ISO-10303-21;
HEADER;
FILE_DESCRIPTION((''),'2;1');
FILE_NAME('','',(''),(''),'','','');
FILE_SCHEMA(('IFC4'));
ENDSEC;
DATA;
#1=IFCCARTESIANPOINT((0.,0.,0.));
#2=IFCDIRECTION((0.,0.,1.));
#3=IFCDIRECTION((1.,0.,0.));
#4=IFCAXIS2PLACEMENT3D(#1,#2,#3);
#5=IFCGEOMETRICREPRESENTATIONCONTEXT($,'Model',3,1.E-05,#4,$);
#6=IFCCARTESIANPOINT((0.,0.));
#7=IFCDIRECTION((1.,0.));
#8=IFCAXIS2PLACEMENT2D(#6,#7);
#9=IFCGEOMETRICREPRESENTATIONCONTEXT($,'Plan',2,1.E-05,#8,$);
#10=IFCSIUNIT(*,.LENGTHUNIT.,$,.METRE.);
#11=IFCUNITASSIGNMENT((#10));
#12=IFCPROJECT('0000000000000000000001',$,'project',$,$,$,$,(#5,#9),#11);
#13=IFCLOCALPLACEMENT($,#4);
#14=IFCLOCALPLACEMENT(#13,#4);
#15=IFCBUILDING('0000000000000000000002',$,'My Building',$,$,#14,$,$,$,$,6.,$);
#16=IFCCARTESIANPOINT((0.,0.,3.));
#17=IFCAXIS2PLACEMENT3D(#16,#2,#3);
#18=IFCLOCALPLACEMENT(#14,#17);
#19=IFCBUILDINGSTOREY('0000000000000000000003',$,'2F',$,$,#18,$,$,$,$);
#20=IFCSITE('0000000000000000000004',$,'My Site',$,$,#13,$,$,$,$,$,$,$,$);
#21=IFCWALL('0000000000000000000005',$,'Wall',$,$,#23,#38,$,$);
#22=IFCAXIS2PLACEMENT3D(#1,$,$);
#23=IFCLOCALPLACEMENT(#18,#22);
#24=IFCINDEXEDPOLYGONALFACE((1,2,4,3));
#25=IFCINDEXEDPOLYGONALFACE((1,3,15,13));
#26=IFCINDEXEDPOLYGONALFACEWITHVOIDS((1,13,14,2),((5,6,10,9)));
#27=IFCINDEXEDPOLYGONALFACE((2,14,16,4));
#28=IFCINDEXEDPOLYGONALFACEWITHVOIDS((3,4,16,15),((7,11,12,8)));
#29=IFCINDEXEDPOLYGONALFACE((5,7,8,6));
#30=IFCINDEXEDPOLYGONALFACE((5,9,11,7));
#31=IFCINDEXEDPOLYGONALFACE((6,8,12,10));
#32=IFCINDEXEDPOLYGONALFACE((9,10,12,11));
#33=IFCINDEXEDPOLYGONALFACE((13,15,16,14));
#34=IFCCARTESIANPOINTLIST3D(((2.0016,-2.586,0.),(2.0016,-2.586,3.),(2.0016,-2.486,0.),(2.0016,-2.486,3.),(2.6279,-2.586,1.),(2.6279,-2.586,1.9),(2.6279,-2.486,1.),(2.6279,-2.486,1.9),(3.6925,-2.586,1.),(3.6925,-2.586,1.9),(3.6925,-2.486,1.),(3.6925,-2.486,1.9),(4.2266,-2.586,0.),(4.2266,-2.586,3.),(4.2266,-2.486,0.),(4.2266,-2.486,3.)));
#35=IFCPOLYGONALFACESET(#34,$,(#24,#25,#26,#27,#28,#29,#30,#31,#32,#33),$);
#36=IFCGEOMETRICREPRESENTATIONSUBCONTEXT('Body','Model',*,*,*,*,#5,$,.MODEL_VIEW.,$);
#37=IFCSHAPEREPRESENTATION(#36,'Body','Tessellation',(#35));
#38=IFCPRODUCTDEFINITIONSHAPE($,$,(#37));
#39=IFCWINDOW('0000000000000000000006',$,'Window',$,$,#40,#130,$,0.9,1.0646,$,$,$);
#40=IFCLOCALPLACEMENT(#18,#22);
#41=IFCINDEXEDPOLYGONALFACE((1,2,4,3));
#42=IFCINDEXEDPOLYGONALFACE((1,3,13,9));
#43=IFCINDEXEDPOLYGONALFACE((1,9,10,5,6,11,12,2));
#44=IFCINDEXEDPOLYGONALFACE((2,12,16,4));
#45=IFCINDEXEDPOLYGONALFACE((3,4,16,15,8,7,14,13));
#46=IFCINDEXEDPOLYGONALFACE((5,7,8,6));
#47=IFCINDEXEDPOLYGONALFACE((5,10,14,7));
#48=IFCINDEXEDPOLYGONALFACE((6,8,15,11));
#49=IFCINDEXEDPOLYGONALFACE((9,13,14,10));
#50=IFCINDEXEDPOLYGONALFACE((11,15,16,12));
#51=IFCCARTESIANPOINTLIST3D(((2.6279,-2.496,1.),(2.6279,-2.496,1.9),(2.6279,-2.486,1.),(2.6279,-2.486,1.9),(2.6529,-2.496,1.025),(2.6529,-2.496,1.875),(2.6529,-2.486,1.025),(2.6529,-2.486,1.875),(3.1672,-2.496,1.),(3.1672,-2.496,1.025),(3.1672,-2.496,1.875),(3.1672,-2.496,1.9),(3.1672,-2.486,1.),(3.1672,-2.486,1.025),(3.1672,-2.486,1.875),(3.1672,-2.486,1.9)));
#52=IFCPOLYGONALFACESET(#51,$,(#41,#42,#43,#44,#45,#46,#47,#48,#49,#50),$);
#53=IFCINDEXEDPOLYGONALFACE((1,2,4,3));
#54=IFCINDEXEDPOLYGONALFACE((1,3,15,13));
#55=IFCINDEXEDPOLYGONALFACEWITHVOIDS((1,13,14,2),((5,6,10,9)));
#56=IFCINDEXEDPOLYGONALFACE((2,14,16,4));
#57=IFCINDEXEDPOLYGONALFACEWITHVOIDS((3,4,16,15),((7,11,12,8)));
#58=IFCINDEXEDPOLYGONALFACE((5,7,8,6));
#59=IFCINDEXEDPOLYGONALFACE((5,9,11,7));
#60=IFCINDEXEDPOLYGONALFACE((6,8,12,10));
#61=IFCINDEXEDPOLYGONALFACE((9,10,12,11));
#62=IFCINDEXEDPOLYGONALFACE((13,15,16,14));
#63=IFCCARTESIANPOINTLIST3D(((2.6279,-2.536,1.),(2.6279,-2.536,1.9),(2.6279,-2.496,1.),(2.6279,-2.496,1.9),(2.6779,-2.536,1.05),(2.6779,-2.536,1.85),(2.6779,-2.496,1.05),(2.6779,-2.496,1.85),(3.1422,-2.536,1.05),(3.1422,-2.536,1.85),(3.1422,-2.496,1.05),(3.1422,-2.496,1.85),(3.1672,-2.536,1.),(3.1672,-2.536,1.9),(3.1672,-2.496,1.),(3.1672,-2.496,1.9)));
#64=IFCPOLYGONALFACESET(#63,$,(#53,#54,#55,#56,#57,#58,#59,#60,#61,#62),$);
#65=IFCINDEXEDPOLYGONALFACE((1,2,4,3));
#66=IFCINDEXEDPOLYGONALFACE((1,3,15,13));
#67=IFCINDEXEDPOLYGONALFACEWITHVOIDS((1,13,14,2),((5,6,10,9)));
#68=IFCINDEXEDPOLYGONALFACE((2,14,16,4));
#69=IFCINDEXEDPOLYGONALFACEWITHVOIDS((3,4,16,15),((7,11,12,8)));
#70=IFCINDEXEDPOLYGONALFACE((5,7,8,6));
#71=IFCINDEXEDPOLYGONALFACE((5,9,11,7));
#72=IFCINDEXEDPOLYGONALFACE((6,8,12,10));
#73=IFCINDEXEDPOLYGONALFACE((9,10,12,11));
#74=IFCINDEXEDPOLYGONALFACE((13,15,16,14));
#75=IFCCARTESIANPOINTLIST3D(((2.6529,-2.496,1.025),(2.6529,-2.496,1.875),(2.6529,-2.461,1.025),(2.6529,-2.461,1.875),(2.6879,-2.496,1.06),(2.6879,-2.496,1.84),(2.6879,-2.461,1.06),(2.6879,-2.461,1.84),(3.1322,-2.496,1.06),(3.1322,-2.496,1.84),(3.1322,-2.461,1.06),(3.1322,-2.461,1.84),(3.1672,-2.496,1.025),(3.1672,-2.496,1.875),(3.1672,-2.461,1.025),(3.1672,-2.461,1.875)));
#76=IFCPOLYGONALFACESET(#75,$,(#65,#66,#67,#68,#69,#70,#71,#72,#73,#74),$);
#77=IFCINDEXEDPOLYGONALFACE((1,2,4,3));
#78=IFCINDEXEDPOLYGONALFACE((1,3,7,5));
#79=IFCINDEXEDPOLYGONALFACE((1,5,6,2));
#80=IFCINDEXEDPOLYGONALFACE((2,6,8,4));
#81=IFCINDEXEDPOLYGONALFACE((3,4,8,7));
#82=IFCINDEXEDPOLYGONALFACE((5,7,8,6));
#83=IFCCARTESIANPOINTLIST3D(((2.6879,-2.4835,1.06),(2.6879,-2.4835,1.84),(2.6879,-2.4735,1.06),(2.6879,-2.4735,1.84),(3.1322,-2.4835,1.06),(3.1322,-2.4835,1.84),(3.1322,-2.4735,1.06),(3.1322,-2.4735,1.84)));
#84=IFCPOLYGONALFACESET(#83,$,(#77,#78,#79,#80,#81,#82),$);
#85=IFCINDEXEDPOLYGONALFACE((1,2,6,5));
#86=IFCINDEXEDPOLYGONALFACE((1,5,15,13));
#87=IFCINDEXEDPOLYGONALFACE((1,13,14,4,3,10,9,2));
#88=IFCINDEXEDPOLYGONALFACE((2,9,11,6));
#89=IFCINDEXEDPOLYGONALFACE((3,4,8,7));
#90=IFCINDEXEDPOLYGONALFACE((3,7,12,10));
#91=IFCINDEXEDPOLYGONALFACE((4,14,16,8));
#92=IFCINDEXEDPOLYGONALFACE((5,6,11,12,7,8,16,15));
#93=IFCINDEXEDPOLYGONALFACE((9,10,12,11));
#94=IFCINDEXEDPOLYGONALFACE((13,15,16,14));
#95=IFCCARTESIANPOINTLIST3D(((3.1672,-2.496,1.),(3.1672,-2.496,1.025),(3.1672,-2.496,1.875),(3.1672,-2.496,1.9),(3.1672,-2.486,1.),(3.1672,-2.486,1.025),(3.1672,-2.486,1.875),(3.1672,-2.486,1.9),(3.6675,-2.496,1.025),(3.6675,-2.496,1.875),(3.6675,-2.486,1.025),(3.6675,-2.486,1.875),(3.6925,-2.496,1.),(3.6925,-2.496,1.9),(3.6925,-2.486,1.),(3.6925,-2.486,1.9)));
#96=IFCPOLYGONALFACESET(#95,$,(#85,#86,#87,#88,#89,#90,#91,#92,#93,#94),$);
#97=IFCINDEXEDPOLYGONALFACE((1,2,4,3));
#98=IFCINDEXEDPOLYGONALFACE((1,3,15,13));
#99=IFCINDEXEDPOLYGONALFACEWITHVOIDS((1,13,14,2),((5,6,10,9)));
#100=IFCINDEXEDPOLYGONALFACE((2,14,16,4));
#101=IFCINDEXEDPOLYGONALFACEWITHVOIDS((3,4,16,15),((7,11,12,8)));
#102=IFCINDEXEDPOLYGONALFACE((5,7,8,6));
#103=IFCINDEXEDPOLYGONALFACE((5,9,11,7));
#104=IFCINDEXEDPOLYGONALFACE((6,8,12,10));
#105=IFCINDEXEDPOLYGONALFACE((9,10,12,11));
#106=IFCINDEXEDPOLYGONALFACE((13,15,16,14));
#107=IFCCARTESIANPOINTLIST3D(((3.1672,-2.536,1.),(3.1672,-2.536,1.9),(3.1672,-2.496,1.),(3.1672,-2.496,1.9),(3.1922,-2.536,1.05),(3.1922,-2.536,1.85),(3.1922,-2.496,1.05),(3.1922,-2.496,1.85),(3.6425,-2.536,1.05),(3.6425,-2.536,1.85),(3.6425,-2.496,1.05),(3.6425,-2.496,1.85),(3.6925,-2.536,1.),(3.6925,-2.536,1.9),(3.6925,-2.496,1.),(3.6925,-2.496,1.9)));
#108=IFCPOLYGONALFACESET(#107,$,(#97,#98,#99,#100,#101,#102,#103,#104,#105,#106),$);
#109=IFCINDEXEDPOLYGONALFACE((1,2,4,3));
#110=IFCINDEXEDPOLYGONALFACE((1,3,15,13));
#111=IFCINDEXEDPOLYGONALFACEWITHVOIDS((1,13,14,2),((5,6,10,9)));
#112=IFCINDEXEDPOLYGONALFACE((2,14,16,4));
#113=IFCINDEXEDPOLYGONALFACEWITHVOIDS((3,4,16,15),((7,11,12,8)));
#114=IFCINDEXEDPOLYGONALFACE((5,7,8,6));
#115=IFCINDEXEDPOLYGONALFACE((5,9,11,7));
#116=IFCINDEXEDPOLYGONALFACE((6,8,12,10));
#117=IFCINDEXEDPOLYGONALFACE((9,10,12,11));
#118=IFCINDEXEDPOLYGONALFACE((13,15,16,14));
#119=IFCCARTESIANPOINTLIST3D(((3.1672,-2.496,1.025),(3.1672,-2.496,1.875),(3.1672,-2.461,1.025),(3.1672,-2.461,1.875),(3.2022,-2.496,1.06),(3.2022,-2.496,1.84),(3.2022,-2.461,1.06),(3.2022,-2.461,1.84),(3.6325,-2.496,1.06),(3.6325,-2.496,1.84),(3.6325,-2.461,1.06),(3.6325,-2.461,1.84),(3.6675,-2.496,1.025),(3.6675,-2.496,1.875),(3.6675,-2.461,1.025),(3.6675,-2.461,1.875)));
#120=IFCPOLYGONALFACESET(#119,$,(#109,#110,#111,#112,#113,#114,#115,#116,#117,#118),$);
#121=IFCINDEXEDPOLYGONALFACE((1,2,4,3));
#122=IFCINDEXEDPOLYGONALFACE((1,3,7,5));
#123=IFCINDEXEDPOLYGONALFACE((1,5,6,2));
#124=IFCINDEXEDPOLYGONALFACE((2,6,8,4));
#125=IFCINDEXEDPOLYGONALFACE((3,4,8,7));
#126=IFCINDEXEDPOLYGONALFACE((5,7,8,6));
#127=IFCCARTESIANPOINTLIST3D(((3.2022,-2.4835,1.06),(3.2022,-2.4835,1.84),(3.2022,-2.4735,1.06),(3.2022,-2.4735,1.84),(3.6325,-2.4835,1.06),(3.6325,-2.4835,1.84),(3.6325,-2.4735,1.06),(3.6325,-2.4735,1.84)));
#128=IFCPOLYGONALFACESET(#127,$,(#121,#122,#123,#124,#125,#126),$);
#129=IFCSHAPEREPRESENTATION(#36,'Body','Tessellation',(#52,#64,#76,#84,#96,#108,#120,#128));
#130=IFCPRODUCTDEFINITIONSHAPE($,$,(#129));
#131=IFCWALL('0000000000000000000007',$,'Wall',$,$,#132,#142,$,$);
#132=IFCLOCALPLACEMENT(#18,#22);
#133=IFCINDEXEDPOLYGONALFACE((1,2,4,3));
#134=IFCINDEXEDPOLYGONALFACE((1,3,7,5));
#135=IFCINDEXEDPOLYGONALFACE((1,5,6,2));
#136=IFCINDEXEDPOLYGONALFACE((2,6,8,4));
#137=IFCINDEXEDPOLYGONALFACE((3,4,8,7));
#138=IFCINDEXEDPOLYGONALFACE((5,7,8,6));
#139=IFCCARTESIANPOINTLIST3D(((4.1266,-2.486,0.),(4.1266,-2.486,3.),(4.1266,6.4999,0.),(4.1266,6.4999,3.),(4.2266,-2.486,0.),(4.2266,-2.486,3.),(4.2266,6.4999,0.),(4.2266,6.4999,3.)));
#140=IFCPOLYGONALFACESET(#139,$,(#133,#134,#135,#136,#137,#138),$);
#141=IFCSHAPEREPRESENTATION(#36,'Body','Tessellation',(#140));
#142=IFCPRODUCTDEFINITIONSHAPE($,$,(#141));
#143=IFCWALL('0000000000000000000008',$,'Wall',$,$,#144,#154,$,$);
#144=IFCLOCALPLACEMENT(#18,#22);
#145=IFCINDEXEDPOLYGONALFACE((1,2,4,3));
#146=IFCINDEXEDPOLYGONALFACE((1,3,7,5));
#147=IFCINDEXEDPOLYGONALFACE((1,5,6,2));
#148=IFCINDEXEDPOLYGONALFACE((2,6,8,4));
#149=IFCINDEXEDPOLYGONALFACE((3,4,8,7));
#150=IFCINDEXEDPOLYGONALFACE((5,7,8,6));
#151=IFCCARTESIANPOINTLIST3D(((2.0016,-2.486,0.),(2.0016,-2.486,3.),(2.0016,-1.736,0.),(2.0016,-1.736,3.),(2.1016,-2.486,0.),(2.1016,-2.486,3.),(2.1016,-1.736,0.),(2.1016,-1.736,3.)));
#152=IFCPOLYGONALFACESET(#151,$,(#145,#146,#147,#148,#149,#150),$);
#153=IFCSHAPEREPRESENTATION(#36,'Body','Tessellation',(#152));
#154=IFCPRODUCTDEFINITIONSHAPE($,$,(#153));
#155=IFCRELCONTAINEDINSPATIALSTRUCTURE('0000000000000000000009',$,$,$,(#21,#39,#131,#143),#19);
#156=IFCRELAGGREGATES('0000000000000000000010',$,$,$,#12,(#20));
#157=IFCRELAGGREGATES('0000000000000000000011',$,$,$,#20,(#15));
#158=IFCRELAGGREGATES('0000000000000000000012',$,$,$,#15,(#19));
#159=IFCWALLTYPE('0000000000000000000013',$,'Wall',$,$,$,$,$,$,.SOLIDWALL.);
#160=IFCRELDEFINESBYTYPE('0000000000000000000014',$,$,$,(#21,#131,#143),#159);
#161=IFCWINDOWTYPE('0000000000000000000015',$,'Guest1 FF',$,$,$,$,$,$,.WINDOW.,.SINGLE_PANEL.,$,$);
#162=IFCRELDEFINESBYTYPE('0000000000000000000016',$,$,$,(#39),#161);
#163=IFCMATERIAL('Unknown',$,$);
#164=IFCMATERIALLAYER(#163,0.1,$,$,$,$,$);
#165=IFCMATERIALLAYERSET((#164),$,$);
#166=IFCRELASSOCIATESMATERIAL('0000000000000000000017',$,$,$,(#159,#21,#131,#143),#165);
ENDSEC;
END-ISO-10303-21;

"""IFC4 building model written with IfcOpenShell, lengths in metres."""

from ifc_helpers import new_model, entity, si_unit, frame, origin_with_axes, origin_2d_with_axis, place, context, subcontext, project, spatial, line, indexed_curve, outline, extrude, shape, source, transform, mapped, material, layer, layer_set, layer_usage, type_object, type_shapes, element, fill, save


model = new_model("IFC4")

# Units and contexts
model_context = context("Model", 3, precision=1e-05, world=origin_with_axes())
plan_context = context("Plan", 2, precision=1e-05, world=origin_2d_with_axis())
body_context_1 = subcontext(model_context, "Body", "Model", "MODEL_VIEW")
body_context_2 = subcontext(plan_context, "Body", "Plan", "PLAN_VIEW")
ifc_project = project(units=[si_unit("LENGTHUNIT", "METRE")], contexts=[model_context, plan_context])

# Site, building, storey
site_placement = place(None, origin_with_axes())
site = spatial("IfcSite", under=ifc_project, at=site_placement, Name="My Site")
building_placement = place(site_placement, origin_with_axes())
building = spatial("IfcBuilding", under=site, at=building_placement, Name="My Building", ElevationOfTerrain=6.0)
storey_placement = place(building_placement, frame((0.0, 0.0, 3.0), z_axis=(0.0, 0.0, 1.0), x_axis=(1.0, 0.0, 0.0)))
storey = spatial("IfcBuildingStorey", under=building, at=storey_placement, Name="2F")

# Shared definitions
ifc_material_1 = material(Name="Unknown")

# Wall, opening, window
ifc_layer_1 = layer(ifc_material_1, 0.1)
ifc_layer_set_1 = layer_set([ifc_layer_1])
ifc_layer_usage_1 = layer_usage(ifc_layer_set_1, "AXIS2", "POSITIVE", 0.0)
wall_type = type_object("IfcWallType", Name="Wall", PredefinedType="SOLIDWALL", material=ifc_layer_set_1)
wall_1_placement = place(storey_placement, frame((4.2266, -2.486, 0.0), z_axis=(0.0, 0.0, 1.0), x_axis=(-1.0, 0.0, 0.0)))
wall_1 = element("IfcWall", 1, at=wall_1_placement, inside=storey, type_object=wall_type, material=ifc_layer_usage_1, Name="Wall", context=body_context_1, shape_type="SweptSolid", body=[
    extrude(outline(indexed_curve([(0.0, 0.0), (0.0, 0.1), (2.225, 0.1), (2.225, 0.0)], segments=[line(1, 2, 3, 4, 1)])), origin_with_axes(), (0.0, 0.0, 1.0), 3.0),
])
shared_shape_1 = source(origin_with_axes(), body_context_1, "Body", "SweptSolid", [
    extrude(outline(indexed_curve([(0.0, 0.0), (1.0646, 0.0), (1.0646, 0.9), (0.0, 0.9)], segments=[line(1, 2, 3, 4, 1)])), frame((0.0, -0.6, 0.0), z_axis=(0.0, -1.0, 0.0), x_axis=(1.0, 0.0, 0.0)), (0.0, 0.0, -1.0), 1.2),
])
opening_1_placement = place(wall_1_placement, frame((1.5987, 0.1, 1.0), z_axis=(0.0, 0.0, 1.0), x_axis=(-1.0, 0.0, 0.0)))
opening_1 = element("IfcOpeningElement", 2, at=opening_1_placement, cuts=wall_1, PredefinedType="OPENING", context=body_context_1, shape_type="MappedRepresentation", body=[
    mapped(shared_shape_1, transform((0.0, 0.0, 0.0), x_axis=(1.0, 0.0, 0.0), y_axis=(0.0, 1.0, 0.0), z_axis=(0.0, 0.0, 1.0), scale=1.0)),
])
window_type = type_object("IfcWindowType", Name="Guest1 FF", PartitioningType="SINGLE_PANEL", PredefinedType="WINDOW")
shared_shape_2 = source(origin_with_axes(), body_context_1, "Body", "SweptSolid", [
    extrude(outline(indexed_curve([(0.5393, 0.0), (0.0, 0.0), (0.0, 0.9), (0.5393, 0.9), (0.5393, 0.875), (0.025, 0.875), (0.025, 0.025), (0.5393, 0.025)], segments=[line(1, 2, 3, 4, 5, 6, 7, 8, 1)])), frame((0.0, 0.09, 0.0), z_axis=(0.0, -1.0, 0.0), x_axis=(1.0, 0.0, 0.0)), (0.0, 0.0, -1.0), 0.01),
    extrude(outline(indexed_curve([(0.0, 0.0), (0.5393, 0.0), (0.5393, 0.9), (0.0, 0.9)], segments=[line(1, 2, 3, 4, 1)]), holes=[indexed_curve([(0.05, 0.05), (0.5143, 0.05), (0.5143, 0.85), (0.05, 0.85)], segments=[line(1, 2, 3, 4, 1)])]), frame((0.0, 0.05, 0.0), z_axis=(0.0, -1.0, 0.0), x_axis=(1.0, 0.0, 0.0)), (0.0, 0.0, -1.0), 0.04),
    extrude(outline(indexed_curve([(0.0, 0.0), (0.5143, 0.0), (0.5143, 0.85), (0.0, 0.85)], segments=[line(1, 2, 3, 4, 1)]), holes=[indexed_curve([(0.035, 0.035), (0.4793, 0.035), (0.4793, 0.815), (0.035, 0.815)], segments=[line(1, 2, 3, 4, 1)])]), frame((0.025, 0.09, 0.025), z_axis=(0.0, -1.0, 0.0), x_axis=(1.0, 0.0, 0.0)), (0.0, 0.0, -1.0), 0.035),
    extrude(outline(indexed_curve([(0.035, 0.035), (0.4793, 0.035), (0.4793, 0.815), (0.035, 0.815)], segments=[line(1, 2, 3, 4, 1)])), frame((0.025, 0.1025, 0.025), z_axis=(0.0, -1.0, 0.0), x_axis=(1.0, 0.0, 0.0)), (0.0, 0.0, -1.0), 0.01),
    extrude(outline(indexed_curve([(0.0, 0.9), (0.5253, 0.9), (0.5253, 0.0), (0.0, 0.0), (0.0, 0.025), (0.5003, 0.025), (0.5003, 0.875), (0.0, 0.875)], segments=[line(1, 2, 3, 4, 5, 6, 7, 8, 1)])), frame((0.5393, 0.09, 0.0), z_axis=(0.0, -1.0, 0.0), x_axis=(1.0, 0.0, 0.0)), (0.0, 0.0, -1.0), 0.01),
    extrude(outline(indexed_curve([(0.0, 0.0), (0.5253, 0.0), (0.5253, 0.9), (0.0, 0.9)], segments=[line(1, 2, 3, 4, 1)]), holes=[indexed_curve([(0.025, 0.05), (0.4753, 0.05), (0.4753, 0.85), (0.025, 0.85)], segments=[line(1, 2, 3, 4, 1)])]), frame((0.5393, 0.05, 0.0), z_axis=(0.0, -1.0, 0.0), x_axis=(1.0, 0.0, 0.0)), (0.0, 0.0, -1.0), 0.04),
    extrude(outline(indexed_curve([(0.0, 0.0), (0.5003, 0.0), (0.5003, 0.85), (0.0, 0.85)], segments=[line(1, 2, 3, 4, 1)]), holes=[indexed_curve([(0.035, 0.035), (0.4653, 0.035), (0.4653, 0.815), (0.035, 0.815)], segments=[line(1, 2, 3, 4, 1)])]), frame((0.5393, 0.09, 0.025), z_axis=(0.0, -1.0, 0.0), x_axis=(1.0, 0.0, 0.0)), (0.0, 0.0, -1.0), 0.035),
    extrude(outline(indexed_curve([(0.035, 0.035), (0.4653, 0.035), (0.4653, 0.815), (0.035, 0.815)], segments=[line(1, 2, 3, 4, 1)])), frame((0.5393, 0.1025, 0.025), z_axis=(0.0, -1.0, 0.0), x_axis=(1.0, 0.0, 0.0)), (0.0, 0.0, -1.0), 0.01),
])
shared_shape_3 = source(origin_with_axes(), body_context_2, "Body", "Curve2D", [
    entity("IfcIndexedPolyCurve", entity("IfcCartesianPointList2D", [[0.05, 0.05], [0.5143, 0.05]])),
    entity("IfcIndexedPolyCurve", entity("IfcCartesianPointList2D", [[0.0, 0.1], [0.025, 0.1], [0.025, 0.09], [0.05, 0.09], [0.05, 0.05], [0.0, 0.05]]), [entity("IfcLineIndex", [1, 2, 3, 4, 5, 6, 1])]),
    entity("IfcIndexedPolyCurve", entity("IfcCartesianPointList2D", [[0.5393, 0.1], [0.5393, 0.1], [0.5393, 0.09], [0.5143, 0.09], [0.5143, 0.05], [0.5393, 0.05]])),
    entity("IfcIndexedPolyCurve", entity("IfcCartesianPointList2D", [[0.025, 0.09], [0.06, 0.09], [0.06, 0.125], [0.025, 0.125]]), [entity("IfcLineIndex", [1, 2, 3, 4, 1])]),
    entity("IfcIndexedPolyCurve", entity("IfcCartesianPointList2D", [[0.5393, 0.09], [0.5043, 0.09], [0.5043, 0.125], [0.5393, 0.125]]), [entity("IfcLineIndex", [1, 2, 3, 4, 1])]),
    entity("IfcIndexedPolyCurve", entity("IfcCartesianPointList2D", [[0.06, 0.09], [0.5043, 0.09]])),
    entity("IfcIndexedPolyCurve", entity("IfcCartesianPointList2D", [[0.06, 0.125], [0.5043, 0.125]])),
    entity("IfcIndexedPolyCurve", entity("IfcCartesianPointList2D", [[0.06, 0.1075], [0.5043, 0.1075]])),
    entity("IfcIndexedPolyCurve", entity("IfcCartesianPointList2D", [[0.5643, 0.05], [1.0146, 0.05]])),
    entity("IfcIndexedPolyCurve", entity("IfcCartesianPointList2D", [[0.5393, 0.1], [0.5393, 0.1], [0.5393, 0.09], [0.5643, 0.09], [0.5643, 0.05], [0.5393, 0.05]])),
    entity("IfcIndexedPolyCurve", entity("IfcCartesianPointList2D", [[1.0646, 0.1], [1.0396, 0.1], [1.0396, 0.09], [1.0146, 0.09], [1.0146, 0.05], [1.0646, 0.05]]), [entity("IfcLineIndex", [1, 2, 3, 4, 5, 6, 1])]),
    entity("IfcIndexedPolyCurve", entity("IfcCartesianPointList2D", [[0.5393, 0.09], [0.5743, 0.09], [0.5743, 0.125], [0.5393, 0.125]]), [entity("IfcLineIndex", [1, 2, 3, 4, 1])]),
    entity("IfcIndexedPolyCurve", entity("IfcCartesianPointList2D", [[1.0396, 0.09], [1.0046, 0.09], [1.0046, 0.125], [1.0396, 0.125]]), [entity("IfcLineIndex", [1, 2, 3, 4, 1])]),
    entity("IfcIndexedPolyCurve", entity("IfcCartesianPointList2D", [[0.5743, 0.09], [1.0046, 0.09]])),
    entity("IfcIndexedPolyCurve", entity("IfcCartesianPointList2D", [[0.5743, 0.125], [1.0046, 0.125]])),
    entity("IfcIndexedPolyCurve", entity("IfcCartesianPointList2D", [[0.5743, 0.1075], [1.0046, 0.1075]])),
])
type_shapes(window_type, [shared_shape_2, shared_shape_3])
window_placement = place(opening_1_placement, frame((0.0, 0.0, 0.0), z_axis=(0.0, 0.0, 1.0), x_axis=(1.0, 0.0, 0.0)))
window = element("IfcWindow", 3, at=window_placement, inside=storey, type_object=window_type, Name="Window", OverallHeight=0.9, OverallWidth=1.0646, shapes=[
    shape(body_context_1, "Body", "MappedRepresentation", [mapped(shared_shape_2, transform((0.0, 0.0, 0.0), x_axis=(1.0, 0.0, 0.0), y_axis=(0.0, 1.0, 0.0), z_axis=(0.0, 0.0, 1.0), scale=1.0))]),
    shape(body_context_2, "Body", "MappedRepresentation", [mapped(shared_shape_3, transform((0.0, 0.0, 0.0), x_axis=(1.0, 0.0, 0.0), y_axis=(0.0, 1.0, 0.0), z_axis=(0.0, 0.0, 1.0), scale=1.0))]),
])
fill(opening_1, window)

# Walls
ifc_layer_usage_2 = layer_usage(ifc_layer_set_1, "AXIS2", "POSITIVE", 0.0)
wall_2_placement = place(storey_placement, frame((4.2266, -2.486, 0.0), z_axis=(0.0, 0.0, 1.0), x_axis=(0.0, 1.0, 0.0)))
element("IfcWall", 4, at=wall_2_placement, inside=storey, type_object=wall_type, material=ifc_layer_usage_2, Name="Wall", context=body_context_1, shape_type="SweptSolid", body=[
    extrude(outline(indexed_curve([(0.0, 0.0), (0.0, 0.1), (8.9859, 0.1), (8.9859, 0.0)], segments=[line(1, 2, 3, 4, 1)])), origin_with_axes(), (0.0, 0.0, 1.0), 3.0),
])
ifc_layer_usage_3 = layer_usage(ifc_layer_set_1, "AXIS2", "POSITIVE", 0.0)
wall_3_placement = place(storey_placement, frame((2.1016, -2.486, 0.0), z_axis=(0.0, 0.0, 1.0), x_axis=(0.0, 1.0, 0.0)))
element("IfcWall", 5, at=wall_3_placement, inside=storey, type_object=wall_type, material=ifc_layer_usage_3, Name="Wall", context=body_context_1, shape_type="SweptSolid", body=[
    extrude(outline(indexed_curve([(0.0, 0.0), (0.0, 0.1), (0.75, 0.1), (0.75, 0.0)], segments=[line(1, 2, 3, 4, 1)])), origin_with_axes(), (0.0, 0.0, 1.0), 3.0),
])

save(model, "model.ifc")
